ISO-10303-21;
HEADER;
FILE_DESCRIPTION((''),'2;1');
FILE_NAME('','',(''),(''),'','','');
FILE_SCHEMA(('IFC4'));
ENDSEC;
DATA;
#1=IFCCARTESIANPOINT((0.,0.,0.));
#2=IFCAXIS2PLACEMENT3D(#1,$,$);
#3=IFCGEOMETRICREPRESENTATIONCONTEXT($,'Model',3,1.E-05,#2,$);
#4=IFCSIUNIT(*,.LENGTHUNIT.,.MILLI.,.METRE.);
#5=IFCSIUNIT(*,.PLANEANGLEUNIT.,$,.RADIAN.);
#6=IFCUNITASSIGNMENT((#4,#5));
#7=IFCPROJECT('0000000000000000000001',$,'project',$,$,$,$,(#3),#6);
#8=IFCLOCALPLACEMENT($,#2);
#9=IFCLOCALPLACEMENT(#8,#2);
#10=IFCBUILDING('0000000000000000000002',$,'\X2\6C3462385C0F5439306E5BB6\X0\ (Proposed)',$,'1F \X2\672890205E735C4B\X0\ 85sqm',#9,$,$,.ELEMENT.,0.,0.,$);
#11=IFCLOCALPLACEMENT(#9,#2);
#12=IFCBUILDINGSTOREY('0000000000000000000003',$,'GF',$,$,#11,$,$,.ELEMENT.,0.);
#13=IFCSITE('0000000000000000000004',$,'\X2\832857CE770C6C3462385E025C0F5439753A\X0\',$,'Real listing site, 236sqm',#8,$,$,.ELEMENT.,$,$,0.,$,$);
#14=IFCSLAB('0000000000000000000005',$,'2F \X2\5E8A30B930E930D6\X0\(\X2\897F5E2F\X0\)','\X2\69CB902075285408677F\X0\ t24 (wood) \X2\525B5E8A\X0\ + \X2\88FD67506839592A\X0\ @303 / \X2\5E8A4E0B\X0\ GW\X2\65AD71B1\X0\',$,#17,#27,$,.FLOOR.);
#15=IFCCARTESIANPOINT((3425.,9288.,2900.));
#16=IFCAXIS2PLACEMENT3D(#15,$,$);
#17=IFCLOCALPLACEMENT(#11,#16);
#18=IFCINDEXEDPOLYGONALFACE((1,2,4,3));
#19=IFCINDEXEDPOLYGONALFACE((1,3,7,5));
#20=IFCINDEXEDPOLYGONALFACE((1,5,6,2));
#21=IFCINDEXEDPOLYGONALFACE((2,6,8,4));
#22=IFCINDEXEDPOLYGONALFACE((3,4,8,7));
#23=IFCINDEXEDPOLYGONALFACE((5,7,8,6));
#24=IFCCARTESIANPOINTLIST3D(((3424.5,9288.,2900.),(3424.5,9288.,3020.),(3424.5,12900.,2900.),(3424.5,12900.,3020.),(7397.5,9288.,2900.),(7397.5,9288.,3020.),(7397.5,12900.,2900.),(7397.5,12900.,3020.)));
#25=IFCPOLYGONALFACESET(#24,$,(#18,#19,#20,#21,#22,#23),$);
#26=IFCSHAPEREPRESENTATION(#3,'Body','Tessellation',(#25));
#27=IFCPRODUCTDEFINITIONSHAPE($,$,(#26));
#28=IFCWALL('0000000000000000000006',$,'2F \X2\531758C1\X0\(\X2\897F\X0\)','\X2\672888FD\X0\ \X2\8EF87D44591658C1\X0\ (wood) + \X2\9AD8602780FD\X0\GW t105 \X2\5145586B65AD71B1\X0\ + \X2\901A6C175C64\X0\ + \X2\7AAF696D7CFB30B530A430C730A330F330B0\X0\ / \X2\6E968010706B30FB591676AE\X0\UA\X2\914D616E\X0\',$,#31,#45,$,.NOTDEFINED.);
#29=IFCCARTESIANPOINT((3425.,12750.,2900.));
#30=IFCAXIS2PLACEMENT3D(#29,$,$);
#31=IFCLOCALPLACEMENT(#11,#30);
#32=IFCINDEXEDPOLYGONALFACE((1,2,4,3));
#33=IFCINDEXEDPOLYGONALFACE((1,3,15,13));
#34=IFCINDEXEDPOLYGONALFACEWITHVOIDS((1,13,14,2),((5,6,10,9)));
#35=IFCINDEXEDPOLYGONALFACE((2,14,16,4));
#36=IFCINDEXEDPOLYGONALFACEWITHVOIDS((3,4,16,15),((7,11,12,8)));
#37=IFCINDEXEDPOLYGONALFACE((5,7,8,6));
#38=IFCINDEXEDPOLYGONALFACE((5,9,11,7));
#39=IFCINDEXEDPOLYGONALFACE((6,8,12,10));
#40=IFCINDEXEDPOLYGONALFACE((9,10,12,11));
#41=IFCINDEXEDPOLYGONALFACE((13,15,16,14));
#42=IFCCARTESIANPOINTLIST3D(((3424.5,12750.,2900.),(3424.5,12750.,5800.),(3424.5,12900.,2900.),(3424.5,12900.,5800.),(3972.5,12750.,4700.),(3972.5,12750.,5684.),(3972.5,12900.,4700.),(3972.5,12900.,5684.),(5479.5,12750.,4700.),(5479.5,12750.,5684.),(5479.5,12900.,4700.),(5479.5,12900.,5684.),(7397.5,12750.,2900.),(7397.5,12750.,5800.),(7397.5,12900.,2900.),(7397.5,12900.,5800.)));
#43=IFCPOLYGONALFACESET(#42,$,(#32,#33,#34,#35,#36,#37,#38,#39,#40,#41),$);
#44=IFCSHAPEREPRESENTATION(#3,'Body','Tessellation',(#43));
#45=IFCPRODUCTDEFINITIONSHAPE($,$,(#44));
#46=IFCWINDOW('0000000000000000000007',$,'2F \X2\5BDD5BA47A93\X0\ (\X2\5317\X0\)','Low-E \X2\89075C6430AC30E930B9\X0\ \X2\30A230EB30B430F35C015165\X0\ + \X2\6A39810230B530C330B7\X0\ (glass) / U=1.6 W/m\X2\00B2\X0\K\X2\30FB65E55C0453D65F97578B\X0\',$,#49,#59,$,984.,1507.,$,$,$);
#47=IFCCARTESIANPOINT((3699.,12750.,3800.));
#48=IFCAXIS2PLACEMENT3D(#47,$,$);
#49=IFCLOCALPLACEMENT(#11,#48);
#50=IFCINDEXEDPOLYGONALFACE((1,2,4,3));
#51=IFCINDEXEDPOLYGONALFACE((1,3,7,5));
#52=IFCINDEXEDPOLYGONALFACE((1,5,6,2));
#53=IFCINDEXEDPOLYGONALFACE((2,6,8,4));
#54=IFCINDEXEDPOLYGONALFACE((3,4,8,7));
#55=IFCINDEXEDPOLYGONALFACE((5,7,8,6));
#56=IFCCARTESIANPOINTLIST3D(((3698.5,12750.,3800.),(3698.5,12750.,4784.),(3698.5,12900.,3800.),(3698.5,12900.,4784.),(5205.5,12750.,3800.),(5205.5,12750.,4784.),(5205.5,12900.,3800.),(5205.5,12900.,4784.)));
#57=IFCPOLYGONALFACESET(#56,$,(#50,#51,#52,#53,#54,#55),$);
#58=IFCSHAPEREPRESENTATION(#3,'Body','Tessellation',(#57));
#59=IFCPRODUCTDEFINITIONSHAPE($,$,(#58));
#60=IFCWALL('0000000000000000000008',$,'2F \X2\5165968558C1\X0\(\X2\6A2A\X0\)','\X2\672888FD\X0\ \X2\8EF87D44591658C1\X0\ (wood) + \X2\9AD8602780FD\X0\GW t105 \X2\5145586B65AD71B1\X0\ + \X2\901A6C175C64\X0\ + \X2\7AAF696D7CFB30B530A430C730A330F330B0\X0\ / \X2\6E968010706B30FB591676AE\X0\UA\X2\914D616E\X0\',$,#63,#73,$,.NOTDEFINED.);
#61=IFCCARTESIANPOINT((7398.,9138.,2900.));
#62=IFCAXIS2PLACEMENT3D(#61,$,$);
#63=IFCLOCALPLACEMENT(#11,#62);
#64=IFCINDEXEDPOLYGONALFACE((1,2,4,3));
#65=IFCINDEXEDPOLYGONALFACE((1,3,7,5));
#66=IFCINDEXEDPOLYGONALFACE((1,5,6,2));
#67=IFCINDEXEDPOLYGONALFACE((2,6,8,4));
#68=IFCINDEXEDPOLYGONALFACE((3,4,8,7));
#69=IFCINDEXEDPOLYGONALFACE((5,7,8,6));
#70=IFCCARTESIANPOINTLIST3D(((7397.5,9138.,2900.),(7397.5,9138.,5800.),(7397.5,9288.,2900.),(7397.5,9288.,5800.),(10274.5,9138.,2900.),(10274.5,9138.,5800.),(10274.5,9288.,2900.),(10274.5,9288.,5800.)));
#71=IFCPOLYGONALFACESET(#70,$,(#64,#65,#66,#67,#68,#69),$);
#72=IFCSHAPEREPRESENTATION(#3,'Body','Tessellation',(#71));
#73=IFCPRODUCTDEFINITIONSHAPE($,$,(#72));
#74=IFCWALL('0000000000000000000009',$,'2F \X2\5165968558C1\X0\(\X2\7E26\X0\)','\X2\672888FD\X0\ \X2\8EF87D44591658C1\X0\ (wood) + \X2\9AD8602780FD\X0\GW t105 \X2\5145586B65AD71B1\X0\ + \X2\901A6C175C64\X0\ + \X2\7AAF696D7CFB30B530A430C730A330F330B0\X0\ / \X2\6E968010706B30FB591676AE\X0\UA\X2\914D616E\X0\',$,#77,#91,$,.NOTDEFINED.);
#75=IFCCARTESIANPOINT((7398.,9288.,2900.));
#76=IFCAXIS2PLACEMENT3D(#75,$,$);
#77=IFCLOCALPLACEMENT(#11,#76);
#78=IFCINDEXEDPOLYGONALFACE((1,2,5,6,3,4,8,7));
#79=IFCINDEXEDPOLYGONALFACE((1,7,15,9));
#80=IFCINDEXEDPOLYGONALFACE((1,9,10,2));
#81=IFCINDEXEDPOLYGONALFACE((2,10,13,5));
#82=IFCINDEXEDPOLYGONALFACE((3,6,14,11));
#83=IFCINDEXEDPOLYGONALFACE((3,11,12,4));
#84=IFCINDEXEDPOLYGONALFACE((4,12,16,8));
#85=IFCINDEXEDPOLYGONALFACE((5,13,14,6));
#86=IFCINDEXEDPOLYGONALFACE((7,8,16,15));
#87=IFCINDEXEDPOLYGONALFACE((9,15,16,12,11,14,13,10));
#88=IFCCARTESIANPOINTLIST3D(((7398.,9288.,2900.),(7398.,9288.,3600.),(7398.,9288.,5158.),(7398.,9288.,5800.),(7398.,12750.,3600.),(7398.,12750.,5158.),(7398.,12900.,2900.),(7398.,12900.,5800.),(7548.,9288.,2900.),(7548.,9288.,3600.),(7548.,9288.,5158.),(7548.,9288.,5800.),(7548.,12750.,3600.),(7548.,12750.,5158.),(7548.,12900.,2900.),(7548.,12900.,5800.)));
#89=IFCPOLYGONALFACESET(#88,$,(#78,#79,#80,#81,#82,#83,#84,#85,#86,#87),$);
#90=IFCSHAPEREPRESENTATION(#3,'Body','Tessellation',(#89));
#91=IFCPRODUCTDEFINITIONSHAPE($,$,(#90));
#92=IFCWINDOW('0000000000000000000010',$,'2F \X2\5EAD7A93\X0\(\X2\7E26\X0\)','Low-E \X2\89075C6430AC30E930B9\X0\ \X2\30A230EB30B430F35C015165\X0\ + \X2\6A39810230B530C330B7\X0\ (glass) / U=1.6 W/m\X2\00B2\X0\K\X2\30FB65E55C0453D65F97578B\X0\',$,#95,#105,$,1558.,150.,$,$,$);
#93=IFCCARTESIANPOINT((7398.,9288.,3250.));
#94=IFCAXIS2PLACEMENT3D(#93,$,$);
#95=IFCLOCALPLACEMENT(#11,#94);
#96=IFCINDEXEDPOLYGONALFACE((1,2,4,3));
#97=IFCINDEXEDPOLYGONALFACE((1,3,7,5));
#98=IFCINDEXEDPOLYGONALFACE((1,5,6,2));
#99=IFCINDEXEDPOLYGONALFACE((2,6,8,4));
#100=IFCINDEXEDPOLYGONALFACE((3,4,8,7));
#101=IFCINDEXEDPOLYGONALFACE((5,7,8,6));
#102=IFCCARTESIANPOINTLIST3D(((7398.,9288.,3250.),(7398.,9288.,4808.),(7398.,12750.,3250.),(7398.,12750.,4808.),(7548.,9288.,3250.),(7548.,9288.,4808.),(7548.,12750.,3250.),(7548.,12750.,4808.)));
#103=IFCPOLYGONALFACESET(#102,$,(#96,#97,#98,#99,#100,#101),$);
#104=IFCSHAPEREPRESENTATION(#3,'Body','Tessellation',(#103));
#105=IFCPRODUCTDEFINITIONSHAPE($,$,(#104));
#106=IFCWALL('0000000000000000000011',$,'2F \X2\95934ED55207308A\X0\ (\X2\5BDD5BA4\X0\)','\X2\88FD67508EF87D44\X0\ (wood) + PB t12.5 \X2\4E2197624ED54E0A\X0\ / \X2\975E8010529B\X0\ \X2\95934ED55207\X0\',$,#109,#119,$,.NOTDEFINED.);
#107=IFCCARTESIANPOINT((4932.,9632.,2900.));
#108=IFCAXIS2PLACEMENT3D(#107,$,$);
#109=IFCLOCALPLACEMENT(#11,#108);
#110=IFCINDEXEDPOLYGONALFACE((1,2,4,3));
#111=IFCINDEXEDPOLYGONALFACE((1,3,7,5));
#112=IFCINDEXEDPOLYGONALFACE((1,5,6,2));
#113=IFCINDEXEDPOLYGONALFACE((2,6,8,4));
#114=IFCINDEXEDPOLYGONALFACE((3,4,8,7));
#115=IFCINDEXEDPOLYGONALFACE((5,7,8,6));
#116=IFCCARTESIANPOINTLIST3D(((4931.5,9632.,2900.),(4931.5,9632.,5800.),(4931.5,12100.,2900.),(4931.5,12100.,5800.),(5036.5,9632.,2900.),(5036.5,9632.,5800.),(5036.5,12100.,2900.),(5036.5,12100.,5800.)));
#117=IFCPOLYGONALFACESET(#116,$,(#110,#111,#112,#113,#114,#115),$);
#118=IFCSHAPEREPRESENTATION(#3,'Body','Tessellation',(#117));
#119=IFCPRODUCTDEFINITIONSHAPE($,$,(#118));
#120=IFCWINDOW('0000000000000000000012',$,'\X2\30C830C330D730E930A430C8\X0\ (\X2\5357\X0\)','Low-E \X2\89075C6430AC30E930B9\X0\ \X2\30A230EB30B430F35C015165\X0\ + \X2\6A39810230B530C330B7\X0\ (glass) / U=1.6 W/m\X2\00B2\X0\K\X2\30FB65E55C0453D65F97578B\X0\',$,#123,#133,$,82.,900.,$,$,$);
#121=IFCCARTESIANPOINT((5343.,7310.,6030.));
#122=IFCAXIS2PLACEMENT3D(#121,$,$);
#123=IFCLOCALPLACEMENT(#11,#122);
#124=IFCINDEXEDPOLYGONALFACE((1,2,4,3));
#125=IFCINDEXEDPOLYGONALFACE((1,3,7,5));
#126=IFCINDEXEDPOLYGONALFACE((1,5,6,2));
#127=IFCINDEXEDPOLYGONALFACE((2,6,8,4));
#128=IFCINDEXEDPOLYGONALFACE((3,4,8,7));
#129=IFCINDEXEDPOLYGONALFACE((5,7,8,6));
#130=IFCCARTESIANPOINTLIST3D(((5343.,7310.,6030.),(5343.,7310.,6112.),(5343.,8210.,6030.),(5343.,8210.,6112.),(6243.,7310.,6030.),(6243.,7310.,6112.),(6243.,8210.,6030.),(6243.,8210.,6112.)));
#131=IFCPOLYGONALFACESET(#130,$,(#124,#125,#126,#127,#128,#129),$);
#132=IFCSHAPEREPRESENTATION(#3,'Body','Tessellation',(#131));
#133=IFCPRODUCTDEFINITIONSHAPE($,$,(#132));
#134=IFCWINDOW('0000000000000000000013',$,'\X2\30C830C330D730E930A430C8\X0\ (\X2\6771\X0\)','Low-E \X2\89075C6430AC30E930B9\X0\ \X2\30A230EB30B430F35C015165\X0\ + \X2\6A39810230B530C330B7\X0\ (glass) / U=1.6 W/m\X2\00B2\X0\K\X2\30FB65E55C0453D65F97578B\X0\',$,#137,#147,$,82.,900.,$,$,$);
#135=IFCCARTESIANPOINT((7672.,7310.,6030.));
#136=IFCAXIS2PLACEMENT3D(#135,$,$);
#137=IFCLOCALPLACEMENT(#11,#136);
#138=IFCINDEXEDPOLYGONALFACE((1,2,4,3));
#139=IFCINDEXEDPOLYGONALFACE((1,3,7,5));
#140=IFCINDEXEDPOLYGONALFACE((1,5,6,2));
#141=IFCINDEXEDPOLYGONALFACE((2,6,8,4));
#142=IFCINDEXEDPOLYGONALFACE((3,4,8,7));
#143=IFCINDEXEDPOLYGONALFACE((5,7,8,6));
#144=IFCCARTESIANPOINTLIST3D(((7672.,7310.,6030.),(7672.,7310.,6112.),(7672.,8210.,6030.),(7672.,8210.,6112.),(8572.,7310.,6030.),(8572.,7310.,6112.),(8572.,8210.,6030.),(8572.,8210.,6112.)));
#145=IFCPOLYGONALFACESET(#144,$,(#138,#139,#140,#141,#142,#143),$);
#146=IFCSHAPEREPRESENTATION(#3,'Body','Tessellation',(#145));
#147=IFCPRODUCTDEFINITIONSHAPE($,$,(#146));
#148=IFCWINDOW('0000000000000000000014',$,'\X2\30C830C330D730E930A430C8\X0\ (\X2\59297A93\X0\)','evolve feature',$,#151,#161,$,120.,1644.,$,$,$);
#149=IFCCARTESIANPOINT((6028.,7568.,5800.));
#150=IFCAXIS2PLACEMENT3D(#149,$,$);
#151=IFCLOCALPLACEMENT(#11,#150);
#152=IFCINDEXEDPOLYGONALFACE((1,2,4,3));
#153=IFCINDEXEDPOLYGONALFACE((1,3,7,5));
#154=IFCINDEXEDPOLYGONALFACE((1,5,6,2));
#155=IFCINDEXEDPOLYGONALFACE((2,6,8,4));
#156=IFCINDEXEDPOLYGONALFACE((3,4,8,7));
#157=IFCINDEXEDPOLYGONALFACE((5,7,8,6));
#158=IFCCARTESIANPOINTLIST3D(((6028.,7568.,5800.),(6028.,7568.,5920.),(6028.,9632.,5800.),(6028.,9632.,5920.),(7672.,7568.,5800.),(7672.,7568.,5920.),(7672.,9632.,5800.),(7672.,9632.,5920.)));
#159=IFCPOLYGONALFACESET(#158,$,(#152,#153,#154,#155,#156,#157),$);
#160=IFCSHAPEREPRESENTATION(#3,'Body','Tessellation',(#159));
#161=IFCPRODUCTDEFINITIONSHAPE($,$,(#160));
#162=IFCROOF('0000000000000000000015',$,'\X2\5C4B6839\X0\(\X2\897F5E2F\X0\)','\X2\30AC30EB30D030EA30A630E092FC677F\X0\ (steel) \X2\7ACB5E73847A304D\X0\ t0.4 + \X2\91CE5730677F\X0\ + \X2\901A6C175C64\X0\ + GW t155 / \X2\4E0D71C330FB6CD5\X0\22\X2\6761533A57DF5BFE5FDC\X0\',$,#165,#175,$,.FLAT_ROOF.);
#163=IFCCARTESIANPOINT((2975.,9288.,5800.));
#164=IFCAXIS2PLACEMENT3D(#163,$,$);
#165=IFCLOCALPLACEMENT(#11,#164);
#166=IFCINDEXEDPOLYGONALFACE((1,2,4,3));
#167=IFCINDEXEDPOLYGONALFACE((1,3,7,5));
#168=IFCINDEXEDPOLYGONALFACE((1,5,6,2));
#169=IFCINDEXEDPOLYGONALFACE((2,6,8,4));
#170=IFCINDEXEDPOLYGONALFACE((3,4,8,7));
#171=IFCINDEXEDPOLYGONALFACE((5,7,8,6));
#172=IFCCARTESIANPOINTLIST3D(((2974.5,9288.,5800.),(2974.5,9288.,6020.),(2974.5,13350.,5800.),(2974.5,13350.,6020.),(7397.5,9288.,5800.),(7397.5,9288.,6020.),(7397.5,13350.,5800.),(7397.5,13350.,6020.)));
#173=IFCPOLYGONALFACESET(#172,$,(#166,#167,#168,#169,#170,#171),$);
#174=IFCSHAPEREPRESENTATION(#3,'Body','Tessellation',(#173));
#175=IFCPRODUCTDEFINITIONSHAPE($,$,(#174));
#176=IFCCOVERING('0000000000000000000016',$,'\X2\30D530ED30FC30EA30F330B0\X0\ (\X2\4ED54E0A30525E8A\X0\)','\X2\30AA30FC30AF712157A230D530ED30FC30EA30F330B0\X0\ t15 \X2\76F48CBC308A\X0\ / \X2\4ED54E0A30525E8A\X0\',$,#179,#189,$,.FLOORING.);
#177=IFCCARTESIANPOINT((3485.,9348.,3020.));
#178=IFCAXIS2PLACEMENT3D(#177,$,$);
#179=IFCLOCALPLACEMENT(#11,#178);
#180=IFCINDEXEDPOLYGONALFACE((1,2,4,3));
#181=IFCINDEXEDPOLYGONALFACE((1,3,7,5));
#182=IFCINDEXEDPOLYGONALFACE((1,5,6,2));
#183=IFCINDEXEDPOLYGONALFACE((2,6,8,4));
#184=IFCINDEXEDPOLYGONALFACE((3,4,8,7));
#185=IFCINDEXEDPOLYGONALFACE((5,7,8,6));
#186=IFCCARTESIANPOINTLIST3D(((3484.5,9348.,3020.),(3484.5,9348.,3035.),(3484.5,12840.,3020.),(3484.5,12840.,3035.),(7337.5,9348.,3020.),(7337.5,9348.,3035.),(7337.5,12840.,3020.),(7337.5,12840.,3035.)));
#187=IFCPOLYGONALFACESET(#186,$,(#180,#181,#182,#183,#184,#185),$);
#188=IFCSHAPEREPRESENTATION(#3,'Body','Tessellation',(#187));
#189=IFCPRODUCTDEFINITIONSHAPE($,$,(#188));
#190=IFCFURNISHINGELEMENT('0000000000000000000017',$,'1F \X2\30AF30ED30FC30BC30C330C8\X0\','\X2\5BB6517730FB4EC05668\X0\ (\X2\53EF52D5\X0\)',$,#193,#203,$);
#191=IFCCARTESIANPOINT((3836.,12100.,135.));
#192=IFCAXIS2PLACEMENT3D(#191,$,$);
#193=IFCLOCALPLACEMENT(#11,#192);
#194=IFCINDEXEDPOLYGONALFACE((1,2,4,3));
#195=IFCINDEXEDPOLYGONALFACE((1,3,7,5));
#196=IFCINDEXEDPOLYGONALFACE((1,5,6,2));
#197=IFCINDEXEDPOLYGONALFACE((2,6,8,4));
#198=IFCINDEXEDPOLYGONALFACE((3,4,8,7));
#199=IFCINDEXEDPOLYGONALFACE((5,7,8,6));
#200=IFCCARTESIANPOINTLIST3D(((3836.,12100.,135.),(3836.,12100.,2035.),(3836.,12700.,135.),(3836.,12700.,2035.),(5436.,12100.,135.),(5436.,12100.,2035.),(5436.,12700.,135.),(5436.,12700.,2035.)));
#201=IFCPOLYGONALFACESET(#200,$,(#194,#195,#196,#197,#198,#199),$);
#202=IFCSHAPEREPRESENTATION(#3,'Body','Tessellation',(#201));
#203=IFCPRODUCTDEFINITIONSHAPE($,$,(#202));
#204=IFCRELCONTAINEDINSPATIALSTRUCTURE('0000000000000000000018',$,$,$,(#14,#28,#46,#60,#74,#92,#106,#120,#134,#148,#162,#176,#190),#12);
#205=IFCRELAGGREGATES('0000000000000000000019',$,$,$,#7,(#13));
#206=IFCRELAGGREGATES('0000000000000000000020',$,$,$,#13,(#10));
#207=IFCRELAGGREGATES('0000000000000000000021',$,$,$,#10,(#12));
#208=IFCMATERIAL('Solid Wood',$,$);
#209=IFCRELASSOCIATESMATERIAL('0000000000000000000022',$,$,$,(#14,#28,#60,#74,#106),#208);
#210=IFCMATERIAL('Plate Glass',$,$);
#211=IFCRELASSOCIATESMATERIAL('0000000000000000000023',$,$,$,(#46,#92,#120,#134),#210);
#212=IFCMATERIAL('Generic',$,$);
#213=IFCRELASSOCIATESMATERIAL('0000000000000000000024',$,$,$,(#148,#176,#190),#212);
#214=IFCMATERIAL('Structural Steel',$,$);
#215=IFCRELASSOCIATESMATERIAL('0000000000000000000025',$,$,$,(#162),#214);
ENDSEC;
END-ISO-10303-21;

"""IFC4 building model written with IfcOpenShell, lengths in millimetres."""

from ifc_helpers import new_model, si_unit, frame, frame_2d, origin, place, context, project, spatial, rectangle, extrude, material, element, fill, save


model = new_model("IFC4")

# Units and contexts
model_context = context("Model", 3, precision=1e-05, world=origin())
ifc_project = project(units=[si_unit("LENGTHUNIT", "METRE", prefix="MILLI"), si_unit("PLANEANGLEUNIT", "RADIAN")], contexts=[model_context])

# Site, building, storey
site_placement = place(None, origin())
site = spatial("IfcSite", under=ifc_project, at=site_placement, Name="茨城県水戸市小吹町", ObjectType="Real listing site, 236sqm", CompositionType="ELEMENT", RefElevation=0.0)
building_placement = place(site_placement, origin())
building = spatial("IfcBuilding", under=site, at=building_placement, Name="水戸小吹の家 (Proposed)", ObjectType="1F 木造平屋 85sqm", CompositionType="ELEMENT", ElevationOfRefHeight=0.0, ElevationOfTerrain=0.0)
storey_placement = place(building_placement, origin())
storey = spatial("IfcBuildingStorey", under=building, at=storey_placement, Name="GF", CompositionType="ELEMENT", Elevation=0.0)

# Slab
ifc_material_1 = material(Name="Solid Wood")
slab_placement = place(storey_placement, frame((3425.0, 9288.0, 2900.0)))
element("IfcSlab", 1, at=slab_placement, inside=storey, material=ifc_material_1, Name="2F 床スラブ(西帯)", Description="構造用合板 t24 (wood) 剛床 + 製材根太 @303 / 床下 GW断熱", PredefinedType="FLOOR", context=model_context, shape_type="SweptSolid", body=[
    extrude(rectangle(XDim=3973.0, YDim=3612.0, at=frame_2d((1986.0, 1806.0))), frame((3425.0, 9288.0, 2900.0)), (0.0, 0.0, 1.0), 120.0),
])

# Wall, opening, window
wall_1_placement = place(storey_placement, frame((3425.0, 12750.0, 2900.0)))
wall_1 = element("IfcWall", 2, at=wall_1_placement, inside=storey, material=ifc_material_1, Name="2F 北壁(西)", Description="木製 軸組外壁 (wood) + 高性能GW t105 充填断熱 + 通気層 + 窯業系サイディング / 準耐火・外皮UA配慮", PredefinedType="NOTDEFINED", context=model_context, shape_type="SweptSolid", body=[
    extrude(rectangle(XDim=3973.0, YDim=150.0, at=frame_2d((1986.0, 75.0))), frame((3425.0, 12750.0, 2900.0)), (0.0, 0.0, 1.0), 2900.0),
])
opening_1_placement = place(storey_placement, frame((3699.0, 12750.0, 3800.0)))
opening_1 = element("IfcOpeningElement", 3, at=opening_1_placement, cuts=wall_1, PredefinedType="NOTDEFINED", context=model_context, shape_type="SweptSolid", body=[
    extrude(rectangle(XDim=1507.0, YDim=150.0, at=frame_2d((753.0, 75.0))), frame((3699.0, 12750.0, 3800.0)), (0.0, 0.0, 1.0), 984.0),
])
ifc_material_2 = material(Name="Plate Glass")
window_1_placement = place(storey_placement, frame((3699.0, 12750.0, 3800.0)))
window_1 = element("IfcWindow", 4, at=window_1_placement, inside=storey, material=ifc_material_2, Name="2F 寝室窓 (北)", Description="Low-E 複層ガラス アルゴン封入 + 樹脂サッシ (glass) / U=1.6 W/m²K・日射取得型", OverallHeight=984.0, OverallWidth=1507.0, context=model_context, shape_type="SweptSolid", body=[
    extrude(rectangle(XDim=1507.0, YDim=150.0, at=frame_2d((753.0, 75.0))), frame((3699.0, 12750.0, 3800.0)), (0.0, 0.0, 1.0), 984.0),
])
fill(opening_1, window_1)

# Wall
wall_2_placement = place(storey_placement, frame((7398.0, 9138.0, 2900.0)))
element("IfcWall", 5, at=wall_2_placement, inside=storey, material=ifc_material_1, Name="2F 入隅壁(横)", Description="木製 軸組外壁 (wood) + 高性能GW t105 充填断熱 + 通気層 + 窯業系サイディング / 準耐火・外皮UA配慮", PredefinedType="NOTDEFINED", context=model_context, shape_type="SweptSolid", body=[
    extrude(rectangle(XDim=2877.0, YDim=150.0, at=frame_2d((1438.0, 75.0))), frame((7398.0, 9138.0, 2900.0)), (0.0, 0.0, 1.0), 2900.0),
])

# Wall, opening, window
wall_3_placement = place(storey_placement, frame((7398.0, 9288.0, 2900.0)))
wall_3 = element("IfcWall", 6, at=wall_3_placement, inside=storey, material=ifc_material_1, Name="2F 入隅壁(縦)", Description="木製 軸組外壁 (wood) + 高性能GW t105 充填断熱 + 通気層 + 窯業系サイディング / 準耐火・外皮UA配慮", PredefinedType="NOTDEFINED", context=model_context, shape_type="SweptSolid", body=[
    extrude(rectangle(XDim=150.0, YDim=3612.0, at=frame_2d((75.0, 1806.0))), frame((7398.0, 9288.0, 2900.0)), (0.0, 0.0, 1.0), 2900.0),
])
opening_2_placement = place(storey_placement, frame((7398.0, 9288.0, 3250.0)))
opening_2 = element("IfcOpeningElement", 7, at=opening_2_placement, cuts=wall_3, PredefinedType="NOTDEFINED", context=model_context, shape_type="SweptSolid", body=[
    extrude(rectangle(XDim=150.0, YDim=3462.0, at=frame_2d((75.0, 1731.0))), frame((7398.0, 9288.0, 3250.0)), (0.0, 0.0, 1.0), 1558.0),
])
window_2_placement = place(storey_placement, frame((7398.0, 9288.0, 3250.0)))
window_2 = element("IfcWindow", 8, at=window_2_placement, inside=storey, material=ifc_material_2, Name="2F 庭窓(縦)", Description="Low-E 複層ガラス アルゴン封入 + 樹脂サッシ (glass) / U=1.6 W/m²K・日射取得型", OverallHeight=1558.0, OverallWidth=150.0, context=model_context, shape_type="SweptSolid", body=[
    extrude(rectangle(XDim=150.0, YDim=3462.0, at=frame_2d((75.0, 1731.0))), frame((7398.0, 9288.0, 3250.0)), (0.0, 0.0, 1.0), 1558.0),
])
fill(opening_2, window_2)

# Wall
wall_4_placement = place(storey_placement, frame((4932.0, 9632.0, 2900.0)))
element("IfcWall", 9, at=wall_4_placement, inside=storey, material=ifc_material_1, Name="2F 間仕切り (寝室)", Description="製材軸組 (wood) + PB t12.5 両面仕上 / 非耐力 間仕切", PredefinedType="NOTDEFINED", context=model_context, shape_type="SweptSolid", body=[
    extrude(rectangle(XDim=105.0, YDim=2468.0, at=frame_2d((52.0, 1234.0))), frame((4932.0, 9632.0, 2900.0)), (0.0, 0.0, 1.0), 2900.0),
])

# Windows
window_3_placement = place(storey_placement, frame((5343.0, 7310.0, 6030.0)))
element("IfcWindow", 10, at=window_3_placement, inside=storey, material=ifc_material_2, Name="トップライト (南)", Description="Low-E 複層ガラス アルゴン封入 + 樹脂サッシ (glass) / U=1.6 W/m²K・日射取得型", OverallHeight=82.0, OverallWidth=900.0, context=model_context, shape_type="SweptSolid", body=[
    extrude(rectangle(XDim=900.0, YDim=900.0, at=frame_2d((450.0, 450.0))), frame((5343.0, 7310.0, 6030.0)), (0.0, 0.0, 1.0), 82.0),
])
window_4_placement = place(storey_placement, frame((7672.0, 7310.0, 6030.0)))
element("IfcWindow", 11, at=window_4_placement, inside=storey, material=ifc_material_2, Name="トップライト (東)", Description="Low-E 複層ガラス アルゴン封入 + 樹脂サッシ (glass) / U=1.6 W/m²K・日射取得型", OverallHeight=82.0, OverallWidth=900.0, context=model_context, shape_type="SweptSolid", body=[
    extrude(rectangle(XDim=900.0, YDim=900.0, at=frame_2d((450.0, 450.0))), frame((7672.0, 7310.0, 6030.0)), (0.0, 0.0, 1.0), 82.0),
])
ifc_material_3 = material(Name="Generic")
window_5_placement = place(storey_placement, frame((6028.0, 7568.0, 5800.0)))
element("IfcWindow", 12, at=window_5_placement, inside=storey, material=ifc_material_3, Name="トップライト (天窓)", Description="evolve feature", OverallHeight=120.0, OverallWidth=1644.0, context=model_context, shape_type="SweptSolid", body=[
    extrude(rectangle(XDim=1644.0, YDim=2064.0, at=frame_2d((822.0, 1032.0))), frame((6028.0, 7568.0, 5800.0)), (0.0, 0.0, 1.0), 120.0),
])

# Roof
ifc_material_4 = material(Name="Structural Steel")
for number, where, name in (
    (13, (2975.0, 9288.0, 5800.0), "屋根(西帯)"),
):
    element("IfcRoof", number, at=place(storey_placement, frame(where)), inside=storey, material=ifc_material_4, Name=name, Description="ガルバリウム鋼板 (steel) 立平葺き t0.4 + 野地板 + 通気層 + GW t155 / 不燃・法22条区域対応", PredefinedType="FLAT_ROOF", context=model_context, shape_type="SweptSolid", body=[
        extrude(rectangle(XDim=4423.0, YDim=4062.0, at=frame_2d((2211.0, 2031.0))), frame((2975.0, 9288.0, 5800.0)), (0.0, 0.0, 1.0), 220.0),
    ])

# Covering
covering_placement = place(storey_placement, frame((3485.0, 9348.0, 3020.0)))
element("IfcCovering", 14, at=covering_placement, inside=storey, material=ifc_material_3, Name="フローリング (仕上げ床)", Description="オーク無垢フローリング t15 直貼り / 仕上げ床", PredefinedType="FLOORING", context=model_context, shape_type="SweptSolid", body=[
    extrude(rectangle(XDim=3853.0, YDim=3492.0, at=frame_2d((1926.0, 1746.0))), frame((3485.0, 9348.0, 3020.0)), (0.0, 0.0, 1.0), 15.0),
])

# Furnishing element
furnishing_1_placement = place(storey_placement, frame((3836.0, 12100.0, 135.0)))
element("IfcFurnishingElement", 15, at=furnishing_1_placement, inside=storey, material=ifc_material_3, Name="1F クローゼット", Description="家具・什器 (可動)", context=model_context, shape_type="SweptSolid", body=[
    extrude(rectangle(XDim=1600.0, YDim=600.0, at=frame_2d((800.0, 300.0))), frame((3836.0, 12100.0, 135.0)), (0.0, 0.0, 1.0), 1900.0),
])

save(model, "model.ifc")
